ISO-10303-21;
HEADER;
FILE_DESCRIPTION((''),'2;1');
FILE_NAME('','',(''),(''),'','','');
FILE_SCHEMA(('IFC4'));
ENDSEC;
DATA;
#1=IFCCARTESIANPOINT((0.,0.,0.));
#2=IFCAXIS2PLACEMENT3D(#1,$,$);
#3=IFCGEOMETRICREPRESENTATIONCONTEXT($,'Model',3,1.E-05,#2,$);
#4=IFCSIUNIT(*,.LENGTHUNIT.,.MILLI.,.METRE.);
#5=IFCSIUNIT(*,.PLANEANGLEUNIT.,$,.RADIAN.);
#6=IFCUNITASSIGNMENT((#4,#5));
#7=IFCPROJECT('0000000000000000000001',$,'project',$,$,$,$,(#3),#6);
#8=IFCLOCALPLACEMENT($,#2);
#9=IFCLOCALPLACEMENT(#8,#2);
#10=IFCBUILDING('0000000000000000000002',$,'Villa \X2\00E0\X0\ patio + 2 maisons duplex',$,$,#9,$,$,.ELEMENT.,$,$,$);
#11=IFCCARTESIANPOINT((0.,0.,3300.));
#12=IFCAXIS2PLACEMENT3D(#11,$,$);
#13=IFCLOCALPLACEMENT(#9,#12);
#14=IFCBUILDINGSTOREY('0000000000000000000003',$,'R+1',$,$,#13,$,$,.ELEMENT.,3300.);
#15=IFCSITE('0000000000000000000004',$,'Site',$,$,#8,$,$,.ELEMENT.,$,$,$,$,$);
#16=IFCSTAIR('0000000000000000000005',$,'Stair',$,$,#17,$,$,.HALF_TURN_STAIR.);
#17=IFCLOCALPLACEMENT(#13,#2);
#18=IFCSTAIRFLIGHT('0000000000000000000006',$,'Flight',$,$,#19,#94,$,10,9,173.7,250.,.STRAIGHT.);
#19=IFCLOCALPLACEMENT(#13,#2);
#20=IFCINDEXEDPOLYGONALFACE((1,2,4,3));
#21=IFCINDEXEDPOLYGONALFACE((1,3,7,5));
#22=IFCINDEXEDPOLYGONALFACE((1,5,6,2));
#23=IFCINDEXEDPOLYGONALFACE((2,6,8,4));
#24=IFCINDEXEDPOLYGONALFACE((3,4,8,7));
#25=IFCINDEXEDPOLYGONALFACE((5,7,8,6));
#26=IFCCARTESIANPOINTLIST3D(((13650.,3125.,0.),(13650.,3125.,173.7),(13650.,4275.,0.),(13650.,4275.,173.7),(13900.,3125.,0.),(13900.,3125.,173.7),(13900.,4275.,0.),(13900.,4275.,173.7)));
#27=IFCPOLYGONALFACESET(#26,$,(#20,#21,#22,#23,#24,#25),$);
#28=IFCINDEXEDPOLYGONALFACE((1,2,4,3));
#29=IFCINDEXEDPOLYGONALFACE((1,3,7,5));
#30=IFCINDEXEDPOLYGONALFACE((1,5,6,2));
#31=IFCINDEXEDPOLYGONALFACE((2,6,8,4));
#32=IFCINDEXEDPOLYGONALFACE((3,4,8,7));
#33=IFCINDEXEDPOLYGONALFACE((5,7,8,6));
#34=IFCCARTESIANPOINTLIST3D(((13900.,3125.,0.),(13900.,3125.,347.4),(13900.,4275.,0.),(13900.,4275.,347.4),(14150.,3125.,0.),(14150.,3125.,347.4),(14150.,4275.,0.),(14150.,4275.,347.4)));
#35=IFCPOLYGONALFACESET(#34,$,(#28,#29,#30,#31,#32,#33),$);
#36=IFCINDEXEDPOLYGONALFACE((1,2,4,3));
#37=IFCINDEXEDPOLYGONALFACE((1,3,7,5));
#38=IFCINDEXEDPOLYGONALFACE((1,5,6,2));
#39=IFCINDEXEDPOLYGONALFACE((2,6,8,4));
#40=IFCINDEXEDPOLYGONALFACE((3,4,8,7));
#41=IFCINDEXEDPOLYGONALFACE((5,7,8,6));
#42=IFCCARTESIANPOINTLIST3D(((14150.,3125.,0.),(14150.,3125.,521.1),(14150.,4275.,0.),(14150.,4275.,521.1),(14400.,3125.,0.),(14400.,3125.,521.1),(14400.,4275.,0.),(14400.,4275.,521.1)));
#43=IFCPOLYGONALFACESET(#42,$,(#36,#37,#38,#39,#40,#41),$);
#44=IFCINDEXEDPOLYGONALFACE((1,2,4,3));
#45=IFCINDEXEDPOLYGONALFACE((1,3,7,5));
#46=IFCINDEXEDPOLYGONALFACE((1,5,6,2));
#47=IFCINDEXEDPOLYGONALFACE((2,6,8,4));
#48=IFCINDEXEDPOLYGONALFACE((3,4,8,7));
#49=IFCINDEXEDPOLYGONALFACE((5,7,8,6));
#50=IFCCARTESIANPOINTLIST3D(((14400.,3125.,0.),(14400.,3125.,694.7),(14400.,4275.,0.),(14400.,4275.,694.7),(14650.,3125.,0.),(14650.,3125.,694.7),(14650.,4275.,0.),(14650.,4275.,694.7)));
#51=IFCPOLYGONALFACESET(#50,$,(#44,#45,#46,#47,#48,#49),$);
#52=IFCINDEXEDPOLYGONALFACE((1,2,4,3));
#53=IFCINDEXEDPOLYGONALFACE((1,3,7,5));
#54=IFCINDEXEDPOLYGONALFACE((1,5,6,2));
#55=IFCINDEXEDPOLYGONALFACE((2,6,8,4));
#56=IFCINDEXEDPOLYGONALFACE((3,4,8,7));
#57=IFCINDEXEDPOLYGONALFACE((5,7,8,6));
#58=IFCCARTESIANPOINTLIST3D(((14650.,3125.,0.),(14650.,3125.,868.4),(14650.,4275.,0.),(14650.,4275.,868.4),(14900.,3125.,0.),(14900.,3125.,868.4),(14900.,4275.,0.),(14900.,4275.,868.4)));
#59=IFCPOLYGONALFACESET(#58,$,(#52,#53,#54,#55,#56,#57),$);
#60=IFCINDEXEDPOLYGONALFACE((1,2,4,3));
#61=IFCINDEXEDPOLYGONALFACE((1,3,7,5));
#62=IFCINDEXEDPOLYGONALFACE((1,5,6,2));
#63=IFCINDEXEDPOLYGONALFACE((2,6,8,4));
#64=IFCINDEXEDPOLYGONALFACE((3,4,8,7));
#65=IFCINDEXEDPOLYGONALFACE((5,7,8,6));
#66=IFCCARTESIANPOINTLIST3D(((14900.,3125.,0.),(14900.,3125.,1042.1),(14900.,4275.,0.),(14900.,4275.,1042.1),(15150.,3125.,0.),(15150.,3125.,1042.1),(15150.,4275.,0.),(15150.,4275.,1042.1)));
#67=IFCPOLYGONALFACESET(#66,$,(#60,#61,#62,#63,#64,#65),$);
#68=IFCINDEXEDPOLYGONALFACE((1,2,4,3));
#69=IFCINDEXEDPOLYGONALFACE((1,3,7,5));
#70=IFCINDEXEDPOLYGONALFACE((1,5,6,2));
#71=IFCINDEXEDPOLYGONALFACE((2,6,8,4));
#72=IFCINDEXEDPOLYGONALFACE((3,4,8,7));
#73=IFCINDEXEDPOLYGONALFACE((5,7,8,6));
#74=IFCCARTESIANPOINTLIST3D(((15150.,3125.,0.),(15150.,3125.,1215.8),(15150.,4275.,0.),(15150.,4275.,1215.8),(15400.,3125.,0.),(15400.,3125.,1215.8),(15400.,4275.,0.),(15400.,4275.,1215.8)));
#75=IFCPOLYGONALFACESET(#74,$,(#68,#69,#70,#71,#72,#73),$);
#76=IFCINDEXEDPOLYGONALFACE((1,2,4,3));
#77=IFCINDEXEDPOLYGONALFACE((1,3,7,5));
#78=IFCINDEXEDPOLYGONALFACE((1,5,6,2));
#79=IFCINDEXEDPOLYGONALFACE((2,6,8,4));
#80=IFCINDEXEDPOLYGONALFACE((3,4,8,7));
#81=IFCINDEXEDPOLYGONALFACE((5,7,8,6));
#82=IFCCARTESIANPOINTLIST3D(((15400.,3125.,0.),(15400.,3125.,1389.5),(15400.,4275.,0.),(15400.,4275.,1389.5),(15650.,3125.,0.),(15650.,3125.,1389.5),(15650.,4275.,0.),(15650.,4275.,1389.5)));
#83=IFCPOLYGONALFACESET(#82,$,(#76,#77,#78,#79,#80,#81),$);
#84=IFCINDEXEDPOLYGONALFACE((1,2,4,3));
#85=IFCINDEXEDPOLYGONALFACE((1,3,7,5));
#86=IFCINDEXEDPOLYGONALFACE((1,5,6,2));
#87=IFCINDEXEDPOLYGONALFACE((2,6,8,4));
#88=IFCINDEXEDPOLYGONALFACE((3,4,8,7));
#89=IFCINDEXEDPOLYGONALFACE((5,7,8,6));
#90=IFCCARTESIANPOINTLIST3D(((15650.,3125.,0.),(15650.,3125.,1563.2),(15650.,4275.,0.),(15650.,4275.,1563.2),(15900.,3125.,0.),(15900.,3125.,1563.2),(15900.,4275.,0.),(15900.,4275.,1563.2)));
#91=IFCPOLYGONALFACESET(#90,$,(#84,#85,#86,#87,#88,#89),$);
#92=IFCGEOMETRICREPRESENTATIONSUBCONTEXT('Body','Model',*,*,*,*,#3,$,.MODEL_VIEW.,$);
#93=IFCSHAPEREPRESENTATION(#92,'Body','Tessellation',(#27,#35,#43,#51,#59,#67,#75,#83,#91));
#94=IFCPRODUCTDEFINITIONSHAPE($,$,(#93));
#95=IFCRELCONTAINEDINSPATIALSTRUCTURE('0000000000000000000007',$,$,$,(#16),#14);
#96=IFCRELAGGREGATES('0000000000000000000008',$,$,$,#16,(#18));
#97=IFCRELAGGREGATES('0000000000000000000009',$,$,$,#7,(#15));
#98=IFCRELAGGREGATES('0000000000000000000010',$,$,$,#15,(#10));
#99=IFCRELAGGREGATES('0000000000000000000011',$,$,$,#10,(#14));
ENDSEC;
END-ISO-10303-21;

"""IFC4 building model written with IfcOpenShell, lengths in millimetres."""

from ifc_helpers import new_model, si_unit, frame, frame_2d, origin, place, context, subcontext, project, spatial, rectangle, extrude, element, aggregate, save


model = new_model("IFC4")

# Units and contexts
model_context = context("Model", 3, precision=1e-05, world=origin())
body_context = subcontext(model_context, "Body", "Model", "MODEL_VIEW")
ifc_project = project(units=[si_unit("LENGTHUNIT", "METRE", prefix="MILLI"), si_unit("PLANEANGLEUNIT", "RADIAN")], contexts=[model_context])

# Site, building, storey
site_placement = place(None, origin())
site = spatial("IfcSite", under=ifc_project, at=site_placement, Name="Site", CompositionType="ELEMENT")
building_placement = place(site_placement, origin())
building = spatial("IfcBuilding", under=site, at=building_placement, Name="Villa à patio + 2 maisons duplex", CompositionType="ELEMENT")
storey_placement = place(building_placement, frame((0.0, 0.0, 3300.0)))
storey = spatial("IfcBuildingStorey", under=building, at=storey_placement, Name="R+1", CompositionType="ELEMENT", Elevation=3300.0)

# Stair, stair flight
stair_1_placement = place(storey_placement, origin())
stair_1 = element("IfcStair", 1, at=stair_1_placement, inside=storey, Name="Stair", PredefinedType="HALF_TURN_STAIR")
stair_flight_1_placement = place(stair_1_placement, frame((13650.0, 3700.0, 0.0), z_axis=(0.0, 0.0, 1.0), x_axis=(1.0, 0.0, 0.0)))
stair_flight_1 = element("IfcStairFlight", 2, at=stair_flight_1_placement, Name="Flight", NumberOfRisers=10, NumberOfTreads=9, PredefinedType="STRAIGHT", RiserHeight=173.7, TreadLength=250.0, context=body_context, shape_type="SweptSolid", body=[
    extrude(rectangle(XDim=250.0, YDim=1150.0, at=frame_2d((125.0, 0.0))), origin(), (0.0, 0.0, 1.0), 173.7),
    extrude(rectangle(XDim=250.0, YDim=1150.0, at=frame_2d((375.0, 0.0))), origin(), (0.0, 0.0, 1.0), 347.4),
    extrude(rectangle(XDim=250.0, YDim=1150.0, at=frame_2d((625.0, 0.0))), origin(), (0.0, 0.0, 1.0), 521.1),
    extrude(rectangle(XDim=250.0, YDim=1150.0, at=frame_2d((875.0, 0.0))), origin(), (0.0, 0.0, 1.0), 694.7),
    extrude(rectangle(XDim=250.0, YDim=1150.0, at=frame_2d((1125.0, 0.0))), origin(), (0.0, 0.0, 1.0), 868.4),
    extrude(rectangle(XDim=250.0, YDim=1150.0, at=frame_2d((1375.0, 0.0))), origin(), (0.0, 0.0, 1.0), 1042.1),
    extrude(rectangle(XDim=250.0, YDim=1150.0, at=frame_2d((1625.0, 0.0))), origin(), (0.0, 0.0, 1.0), 1215.8),
    extrude(rectangle(XDim=250.0, YDim=1150.0, at=frame_2d((1875.0, 0.0))), origin(), (0.0, 0.0, 1.0), 1389.5),
    extrude(rectangle(XDim=250.0, YDim=1150.0, at=frame_2d((2125.0, 0.0))), origin(), (0.0, 0.0, 1.0), 1563.2),
])
aggregate(stair_1, [stair_flight_1])

save(model, "model.ifc")
